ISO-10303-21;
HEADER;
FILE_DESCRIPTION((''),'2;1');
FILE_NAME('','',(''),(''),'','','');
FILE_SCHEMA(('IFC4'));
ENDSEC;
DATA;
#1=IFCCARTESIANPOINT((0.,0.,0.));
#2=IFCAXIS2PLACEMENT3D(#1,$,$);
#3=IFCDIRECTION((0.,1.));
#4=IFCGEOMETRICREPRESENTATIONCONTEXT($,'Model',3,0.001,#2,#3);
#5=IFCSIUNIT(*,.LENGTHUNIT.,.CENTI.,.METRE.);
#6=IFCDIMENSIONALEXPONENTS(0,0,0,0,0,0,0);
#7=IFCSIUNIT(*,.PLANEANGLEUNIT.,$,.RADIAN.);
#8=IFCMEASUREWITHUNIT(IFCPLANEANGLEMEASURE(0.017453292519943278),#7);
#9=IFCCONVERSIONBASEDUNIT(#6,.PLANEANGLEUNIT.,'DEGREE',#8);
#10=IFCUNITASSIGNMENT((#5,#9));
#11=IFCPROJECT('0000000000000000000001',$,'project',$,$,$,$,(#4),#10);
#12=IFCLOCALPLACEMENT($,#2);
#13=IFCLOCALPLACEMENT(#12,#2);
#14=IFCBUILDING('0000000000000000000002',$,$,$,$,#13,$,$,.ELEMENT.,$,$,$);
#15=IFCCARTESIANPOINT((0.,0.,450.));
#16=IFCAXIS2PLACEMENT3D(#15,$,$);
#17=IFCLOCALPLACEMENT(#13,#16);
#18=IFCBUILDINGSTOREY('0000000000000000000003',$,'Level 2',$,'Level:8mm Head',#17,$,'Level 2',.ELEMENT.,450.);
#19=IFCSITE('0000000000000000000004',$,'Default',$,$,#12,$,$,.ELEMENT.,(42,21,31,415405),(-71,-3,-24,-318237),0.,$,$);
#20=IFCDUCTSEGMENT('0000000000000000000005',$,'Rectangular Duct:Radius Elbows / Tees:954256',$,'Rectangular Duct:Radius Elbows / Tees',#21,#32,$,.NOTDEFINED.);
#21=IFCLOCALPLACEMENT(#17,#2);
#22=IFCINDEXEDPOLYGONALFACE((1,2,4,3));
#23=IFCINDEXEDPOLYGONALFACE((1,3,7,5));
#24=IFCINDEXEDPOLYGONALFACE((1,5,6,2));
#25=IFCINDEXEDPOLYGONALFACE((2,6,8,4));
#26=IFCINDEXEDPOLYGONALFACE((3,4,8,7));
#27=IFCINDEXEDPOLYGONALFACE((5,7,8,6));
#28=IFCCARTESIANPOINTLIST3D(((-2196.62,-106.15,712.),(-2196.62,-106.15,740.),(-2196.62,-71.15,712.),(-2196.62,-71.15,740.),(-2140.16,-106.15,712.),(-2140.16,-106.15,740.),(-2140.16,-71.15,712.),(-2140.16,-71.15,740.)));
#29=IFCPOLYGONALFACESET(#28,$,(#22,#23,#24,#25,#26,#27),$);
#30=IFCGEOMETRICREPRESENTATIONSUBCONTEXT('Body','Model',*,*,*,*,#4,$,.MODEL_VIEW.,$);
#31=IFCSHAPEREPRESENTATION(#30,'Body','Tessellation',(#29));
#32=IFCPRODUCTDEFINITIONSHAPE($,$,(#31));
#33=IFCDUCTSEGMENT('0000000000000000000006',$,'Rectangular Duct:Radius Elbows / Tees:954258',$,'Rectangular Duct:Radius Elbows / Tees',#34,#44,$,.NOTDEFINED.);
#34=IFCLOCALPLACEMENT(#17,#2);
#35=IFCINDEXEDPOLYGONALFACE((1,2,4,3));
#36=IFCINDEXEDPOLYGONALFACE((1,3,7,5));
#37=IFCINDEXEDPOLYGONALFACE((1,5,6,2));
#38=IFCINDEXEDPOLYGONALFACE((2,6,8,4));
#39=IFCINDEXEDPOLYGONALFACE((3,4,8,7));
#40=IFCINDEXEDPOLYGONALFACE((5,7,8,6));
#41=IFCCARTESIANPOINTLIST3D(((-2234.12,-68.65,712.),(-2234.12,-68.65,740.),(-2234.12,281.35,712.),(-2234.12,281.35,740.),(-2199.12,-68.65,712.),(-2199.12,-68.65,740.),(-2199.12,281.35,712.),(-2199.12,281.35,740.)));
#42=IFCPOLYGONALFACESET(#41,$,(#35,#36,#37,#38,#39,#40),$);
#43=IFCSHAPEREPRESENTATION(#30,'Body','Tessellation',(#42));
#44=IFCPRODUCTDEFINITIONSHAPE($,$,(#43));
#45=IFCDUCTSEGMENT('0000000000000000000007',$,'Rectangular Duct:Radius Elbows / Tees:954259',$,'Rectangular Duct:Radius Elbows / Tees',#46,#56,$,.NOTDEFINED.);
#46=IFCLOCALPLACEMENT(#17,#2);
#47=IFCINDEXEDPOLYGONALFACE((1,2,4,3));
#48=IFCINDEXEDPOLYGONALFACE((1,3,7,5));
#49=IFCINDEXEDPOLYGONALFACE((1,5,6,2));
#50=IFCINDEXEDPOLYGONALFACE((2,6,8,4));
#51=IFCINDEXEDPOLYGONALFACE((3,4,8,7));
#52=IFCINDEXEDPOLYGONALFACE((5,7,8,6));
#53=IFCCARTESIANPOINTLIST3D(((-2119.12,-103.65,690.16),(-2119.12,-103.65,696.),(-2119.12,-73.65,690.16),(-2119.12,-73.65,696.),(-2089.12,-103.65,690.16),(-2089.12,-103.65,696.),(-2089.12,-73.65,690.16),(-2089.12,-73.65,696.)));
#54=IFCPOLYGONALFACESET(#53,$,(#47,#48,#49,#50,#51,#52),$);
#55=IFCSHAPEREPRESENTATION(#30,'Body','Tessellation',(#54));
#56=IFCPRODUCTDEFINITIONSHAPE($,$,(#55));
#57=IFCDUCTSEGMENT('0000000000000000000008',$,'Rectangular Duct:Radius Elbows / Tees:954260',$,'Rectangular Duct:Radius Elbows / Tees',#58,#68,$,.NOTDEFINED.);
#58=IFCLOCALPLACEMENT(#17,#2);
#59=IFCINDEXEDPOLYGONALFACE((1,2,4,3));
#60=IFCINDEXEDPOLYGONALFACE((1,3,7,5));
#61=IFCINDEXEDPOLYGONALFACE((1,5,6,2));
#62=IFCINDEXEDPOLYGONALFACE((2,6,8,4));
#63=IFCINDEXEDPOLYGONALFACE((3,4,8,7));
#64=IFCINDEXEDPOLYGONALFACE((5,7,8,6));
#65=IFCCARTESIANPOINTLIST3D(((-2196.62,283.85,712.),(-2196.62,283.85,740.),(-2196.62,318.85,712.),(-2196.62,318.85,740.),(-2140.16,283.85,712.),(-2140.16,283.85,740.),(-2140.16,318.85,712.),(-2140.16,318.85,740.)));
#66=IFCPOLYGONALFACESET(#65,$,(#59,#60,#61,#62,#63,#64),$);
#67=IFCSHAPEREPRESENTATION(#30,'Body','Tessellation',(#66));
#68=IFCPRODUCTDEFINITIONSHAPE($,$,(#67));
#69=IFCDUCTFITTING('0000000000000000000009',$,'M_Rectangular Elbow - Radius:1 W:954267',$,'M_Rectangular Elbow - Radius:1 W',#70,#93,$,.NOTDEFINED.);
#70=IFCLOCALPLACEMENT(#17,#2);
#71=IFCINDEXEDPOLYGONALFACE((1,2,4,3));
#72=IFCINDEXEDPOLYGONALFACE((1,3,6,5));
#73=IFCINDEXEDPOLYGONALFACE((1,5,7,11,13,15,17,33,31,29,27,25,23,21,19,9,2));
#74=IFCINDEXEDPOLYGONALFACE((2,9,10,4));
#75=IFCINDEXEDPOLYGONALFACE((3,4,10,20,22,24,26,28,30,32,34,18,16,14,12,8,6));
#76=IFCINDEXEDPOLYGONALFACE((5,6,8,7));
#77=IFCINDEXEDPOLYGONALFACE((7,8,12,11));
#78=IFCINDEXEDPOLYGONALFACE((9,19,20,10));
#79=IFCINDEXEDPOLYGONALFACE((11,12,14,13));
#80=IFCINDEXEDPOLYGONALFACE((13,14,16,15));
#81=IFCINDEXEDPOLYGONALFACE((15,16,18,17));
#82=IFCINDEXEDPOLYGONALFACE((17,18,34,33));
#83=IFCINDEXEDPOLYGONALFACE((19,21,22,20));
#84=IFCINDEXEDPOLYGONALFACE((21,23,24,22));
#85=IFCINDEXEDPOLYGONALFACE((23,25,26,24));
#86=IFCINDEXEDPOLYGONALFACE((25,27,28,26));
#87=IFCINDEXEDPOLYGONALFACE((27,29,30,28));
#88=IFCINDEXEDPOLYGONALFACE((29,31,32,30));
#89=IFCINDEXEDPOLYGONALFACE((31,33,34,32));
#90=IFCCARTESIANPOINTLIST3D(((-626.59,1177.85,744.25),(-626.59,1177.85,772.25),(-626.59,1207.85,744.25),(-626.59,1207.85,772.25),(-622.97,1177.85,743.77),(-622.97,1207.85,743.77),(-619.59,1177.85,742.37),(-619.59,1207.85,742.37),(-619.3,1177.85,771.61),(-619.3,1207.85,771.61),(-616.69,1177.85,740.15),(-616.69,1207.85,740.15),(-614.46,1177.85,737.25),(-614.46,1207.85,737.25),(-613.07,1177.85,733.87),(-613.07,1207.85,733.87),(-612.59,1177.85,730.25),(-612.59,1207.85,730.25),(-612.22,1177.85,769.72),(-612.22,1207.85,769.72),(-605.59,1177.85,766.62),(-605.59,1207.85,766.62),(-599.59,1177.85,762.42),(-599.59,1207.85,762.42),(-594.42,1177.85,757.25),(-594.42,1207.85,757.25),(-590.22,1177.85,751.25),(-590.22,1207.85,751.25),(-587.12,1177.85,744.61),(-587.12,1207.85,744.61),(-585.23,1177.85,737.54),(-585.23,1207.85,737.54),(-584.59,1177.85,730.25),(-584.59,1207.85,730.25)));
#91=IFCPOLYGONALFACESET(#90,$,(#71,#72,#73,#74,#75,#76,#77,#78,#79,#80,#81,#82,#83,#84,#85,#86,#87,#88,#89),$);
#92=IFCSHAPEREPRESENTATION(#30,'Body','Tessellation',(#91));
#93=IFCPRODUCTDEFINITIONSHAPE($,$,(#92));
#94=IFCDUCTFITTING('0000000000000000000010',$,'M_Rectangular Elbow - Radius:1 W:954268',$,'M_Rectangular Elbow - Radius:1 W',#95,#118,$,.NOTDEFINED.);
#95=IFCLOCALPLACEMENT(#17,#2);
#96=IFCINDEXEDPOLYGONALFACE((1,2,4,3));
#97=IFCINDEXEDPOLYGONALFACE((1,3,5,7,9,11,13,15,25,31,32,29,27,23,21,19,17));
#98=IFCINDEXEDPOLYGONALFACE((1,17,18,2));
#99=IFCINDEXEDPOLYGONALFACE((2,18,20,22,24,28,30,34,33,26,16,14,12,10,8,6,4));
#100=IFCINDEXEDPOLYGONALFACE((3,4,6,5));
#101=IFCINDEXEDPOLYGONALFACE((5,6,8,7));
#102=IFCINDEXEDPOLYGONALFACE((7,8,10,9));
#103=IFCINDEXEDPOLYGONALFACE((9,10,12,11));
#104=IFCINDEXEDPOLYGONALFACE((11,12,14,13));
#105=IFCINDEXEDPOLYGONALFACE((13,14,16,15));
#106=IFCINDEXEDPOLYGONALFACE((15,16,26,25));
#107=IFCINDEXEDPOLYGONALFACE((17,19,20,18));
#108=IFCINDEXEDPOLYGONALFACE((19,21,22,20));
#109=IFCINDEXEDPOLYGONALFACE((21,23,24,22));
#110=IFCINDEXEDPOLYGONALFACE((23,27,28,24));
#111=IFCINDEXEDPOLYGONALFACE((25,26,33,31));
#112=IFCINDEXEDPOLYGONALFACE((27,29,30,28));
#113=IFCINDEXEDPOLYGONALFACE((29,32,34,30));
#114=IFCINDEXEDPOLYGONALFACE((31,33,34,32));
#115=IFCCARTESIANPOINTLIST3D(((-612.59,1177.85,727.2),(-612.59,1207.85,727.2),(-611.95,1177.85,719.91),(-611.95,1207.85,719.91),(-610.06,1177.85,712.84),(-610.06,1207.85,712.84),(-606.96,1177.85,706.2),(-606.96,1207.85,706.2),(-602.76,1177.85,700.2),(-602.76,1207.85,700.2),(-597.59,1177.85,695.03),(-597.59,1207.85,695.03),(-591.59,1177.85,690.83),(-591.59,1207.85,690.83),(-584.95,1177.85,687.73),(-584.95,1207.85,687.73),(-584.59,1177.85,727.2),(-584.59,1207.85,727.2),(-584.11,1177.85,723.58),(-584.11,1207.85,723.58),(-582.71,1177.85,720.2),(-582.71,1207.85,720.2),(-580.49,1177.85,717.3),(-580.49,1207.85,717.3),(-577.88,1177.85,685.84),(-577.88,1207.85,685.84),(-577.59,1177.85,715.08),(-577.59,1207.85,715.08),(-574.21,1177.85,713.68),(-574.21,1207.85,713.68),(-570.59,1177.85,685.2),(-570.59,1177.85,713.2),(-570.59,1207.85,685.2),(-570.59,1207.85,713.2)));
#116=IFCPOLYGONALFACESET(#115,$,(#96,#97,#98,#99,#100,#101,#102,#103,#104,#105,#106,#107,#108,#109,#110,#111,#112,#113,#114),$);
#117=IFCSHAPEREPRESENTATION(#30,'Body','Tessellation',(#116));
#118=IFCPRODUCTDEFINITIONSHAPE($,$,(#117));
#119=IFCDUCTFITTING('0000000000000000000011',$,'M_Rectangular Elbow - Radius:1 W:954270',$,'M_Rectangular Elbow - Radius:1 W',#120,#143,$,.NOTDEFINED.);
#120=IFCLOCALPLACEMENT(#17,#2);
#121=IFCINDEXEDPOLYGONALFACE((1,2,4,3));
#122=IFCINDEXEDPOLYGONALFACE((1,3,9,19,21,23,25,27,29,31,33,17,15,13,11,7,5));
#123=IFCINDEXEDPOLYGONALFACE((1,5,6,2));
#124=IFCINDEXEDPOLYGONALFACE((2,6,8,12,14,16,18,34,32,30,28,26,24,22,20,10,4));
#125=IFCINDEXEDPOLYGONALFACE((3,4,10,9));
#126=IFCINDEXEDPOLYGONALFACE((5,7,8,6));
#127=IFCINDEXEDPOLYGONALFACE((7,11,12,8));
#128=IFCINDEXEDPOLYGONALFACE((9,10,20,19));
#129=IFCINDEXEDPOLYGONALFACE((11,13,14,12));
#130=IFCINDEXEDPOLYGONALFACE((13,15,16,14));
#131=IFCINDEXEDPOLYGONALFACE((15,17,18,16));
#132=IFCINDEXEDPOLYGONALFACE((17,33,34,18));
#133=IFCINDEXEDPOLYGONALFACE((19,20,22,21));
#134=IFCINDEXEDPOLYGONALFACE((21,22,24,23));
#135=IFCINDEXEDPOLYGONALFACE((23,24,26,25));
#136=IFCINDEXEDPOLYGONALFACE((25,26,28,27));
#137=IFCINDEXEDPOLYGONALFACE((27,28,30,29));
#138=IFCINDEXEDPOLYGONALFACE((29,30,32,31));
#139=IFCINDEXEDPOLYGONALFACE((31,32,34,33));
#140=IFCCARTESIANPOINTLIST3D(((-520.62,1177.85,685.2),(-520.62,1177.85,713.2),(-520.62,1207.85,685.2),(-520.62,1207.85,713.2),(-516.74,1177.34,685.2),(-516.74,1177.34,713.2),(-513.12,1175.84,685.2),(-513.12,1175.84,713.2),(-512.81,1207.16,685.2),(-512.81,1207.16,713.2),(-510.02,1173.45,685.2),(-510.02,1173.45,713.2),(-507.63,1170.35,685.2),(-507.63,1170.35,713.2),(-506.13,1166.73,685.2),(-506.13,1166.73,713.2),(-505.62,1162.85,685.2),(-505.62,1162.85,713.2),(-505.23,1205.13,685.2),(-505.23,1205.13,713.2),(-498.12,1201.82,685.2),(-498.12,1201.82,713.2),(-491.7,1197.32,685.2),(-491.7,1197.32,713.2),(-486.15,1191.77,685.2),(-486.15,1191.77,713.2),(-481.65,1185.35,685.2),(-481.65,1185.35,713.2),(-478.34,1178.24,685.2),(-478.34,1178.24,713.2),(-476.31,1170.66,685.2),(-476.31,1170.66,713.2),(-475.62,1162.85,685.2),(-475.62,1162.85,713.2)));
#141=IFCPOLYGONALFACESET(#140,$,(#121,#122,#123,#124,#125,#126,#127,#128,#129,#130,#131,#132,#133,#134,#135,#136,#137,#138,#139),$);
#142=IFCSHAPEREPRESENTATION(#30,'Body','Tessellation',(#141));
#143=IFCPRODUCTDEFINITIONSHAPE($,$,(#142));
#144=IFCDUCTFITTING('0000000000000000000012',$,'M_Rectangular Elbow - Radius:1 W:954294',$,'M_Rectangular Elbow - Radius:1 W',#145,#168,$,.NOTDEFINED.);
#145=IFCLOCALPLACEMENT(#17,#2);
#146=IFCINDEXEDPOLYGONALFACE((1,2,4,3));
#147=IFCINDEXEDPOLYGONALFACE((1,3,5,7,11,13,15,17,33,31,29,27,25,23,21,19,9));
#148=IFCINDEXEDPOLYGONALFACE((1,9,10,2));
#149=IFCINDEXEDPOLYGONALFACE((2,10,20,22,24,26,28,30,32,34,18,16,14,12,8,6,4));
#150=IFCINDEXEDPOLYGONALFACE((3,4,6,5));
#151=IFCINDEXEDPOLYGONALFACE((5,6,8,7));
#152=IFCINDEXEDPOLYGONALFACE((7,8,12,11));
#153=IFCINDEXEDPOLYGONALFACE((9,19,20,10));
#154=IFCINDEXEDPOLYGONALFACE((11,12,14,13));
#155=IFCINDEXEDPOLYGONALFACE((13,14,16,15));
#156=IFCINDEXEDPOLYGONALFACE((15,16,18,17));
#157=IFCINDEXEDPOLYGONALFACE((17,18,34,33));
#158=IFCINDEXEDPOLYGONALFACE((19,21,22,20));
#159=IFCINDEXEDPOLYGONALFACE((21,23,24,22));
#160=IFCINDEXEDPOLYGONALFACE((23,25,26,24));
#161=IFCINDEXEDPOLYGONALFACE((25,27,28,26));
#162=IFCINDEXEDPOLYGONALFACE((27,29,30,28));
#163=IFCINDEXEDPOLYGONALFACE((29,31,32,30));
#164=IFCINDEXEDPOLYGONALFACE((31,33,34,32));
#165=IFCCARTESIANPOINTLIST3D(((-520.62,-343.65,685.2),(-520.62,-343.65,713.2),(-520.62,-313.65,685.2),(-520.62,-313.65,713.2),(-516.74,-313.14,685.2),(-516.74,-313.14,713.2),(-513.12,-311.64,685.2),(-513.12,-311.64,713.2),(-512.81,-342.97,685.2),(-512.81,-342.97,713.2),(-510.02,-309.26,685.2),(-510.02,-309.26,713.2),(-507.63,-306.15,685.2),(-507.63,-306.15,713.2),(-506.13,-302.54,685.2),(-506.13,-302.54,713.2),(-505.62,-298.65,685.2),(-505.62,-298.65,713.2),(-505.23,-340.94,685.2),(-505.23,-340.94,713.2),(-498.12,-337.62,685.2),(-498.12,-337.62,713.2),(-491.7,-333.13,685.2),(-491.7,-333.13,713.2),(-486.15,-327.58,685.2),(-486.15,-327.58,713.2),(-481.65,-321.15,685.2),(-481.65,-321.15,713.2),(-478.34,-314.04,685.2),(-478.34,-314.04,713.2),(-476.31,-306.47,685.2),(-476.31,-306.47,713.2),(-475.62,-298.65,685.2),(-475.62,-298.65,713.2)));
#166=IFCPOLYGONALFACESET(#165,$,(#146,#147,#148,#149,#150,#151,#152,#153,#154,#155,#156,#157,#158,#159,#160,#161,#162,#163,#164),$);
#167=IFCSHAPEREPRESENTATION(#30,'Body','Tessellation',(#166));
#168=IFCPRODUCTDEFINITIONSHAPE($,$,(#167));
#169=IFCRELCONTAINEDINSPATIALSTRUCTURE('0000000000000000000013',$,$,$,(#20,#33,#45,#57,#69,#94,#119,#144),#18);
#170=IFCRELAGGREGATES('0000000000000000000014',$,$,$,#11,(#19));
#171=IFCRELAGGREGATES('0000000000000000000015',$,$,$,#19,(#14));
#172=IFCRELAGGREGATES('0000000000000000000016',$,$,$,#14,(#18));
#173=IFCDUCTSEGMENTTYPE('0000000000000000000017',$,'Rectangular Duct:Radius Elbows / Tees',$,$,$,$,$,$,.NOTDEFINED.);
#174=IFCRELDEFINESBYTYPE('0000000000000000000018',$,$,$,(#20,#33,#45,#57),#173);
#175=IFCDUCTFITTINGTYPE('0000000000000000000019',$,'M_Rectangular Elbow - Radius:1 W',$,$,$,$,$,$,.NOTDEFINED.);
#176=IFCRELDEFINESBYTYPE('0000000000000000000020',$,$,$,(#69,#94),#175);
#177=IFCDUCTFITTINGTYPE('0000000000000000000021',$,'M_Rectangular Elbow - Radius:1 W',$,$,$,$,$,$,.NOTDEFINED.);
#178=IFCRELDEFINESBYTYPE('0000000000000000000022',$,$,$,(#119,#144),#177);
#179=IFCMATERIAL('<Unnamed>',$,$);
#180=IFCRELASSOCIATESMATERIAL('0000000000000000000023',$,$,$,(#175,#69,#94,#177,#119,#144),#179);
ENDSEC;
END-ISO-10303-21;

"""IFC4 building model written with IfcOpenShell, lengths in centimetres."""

from ifc_helpers import new_model, entity, si_unit, converted_unit, direction, frame, origin, place, context, subcontext, project, spatial, line, arc, indexed_curve, outline, extrude, source, transform, mapped, material, type_object, type_shapes, element, save


model = new_model("IFC4")

# Units and contexts
model_context = context("Model", 3, precision=0.001, world=origin(), true_north=direction((0.0, 1.0)))
body_context = subcontext(model_context, "Body", "Model", "MODEL_VIEW")
ifc_project = project(units=[si_unit("LENGTHUNIT", "METRE", prefix="CENTI"), converted_unit("PLANEANGLEUNIT", "DEGREE", entity("IfcPlaneAngleMeasure", 0.017453292519943278), si_unit("PLANEANGLEUNIT", "RADIAN"), dimensions=[0, 0, 0, 0, 0, 0, 0])], contexts=[model_context])

# Site, building, storey
site_placement = place(None, origin())
site = spatial("IfcSite", under=ifc_project, at=site_placement, Name="Default", CompositionType="ELEMENT", RefLatitude=(42, 21, 31, 415405), RefLongitude=(-71, -3, -24, -318237), RefElevation=0.0)
building_placement = place(site_placement, origin())
building = spatial("IfcBuilding", under=site, at=building_placement, CompositionType="ELEMENT")
storey_placement = place(building_placement, frame((0.0, 0.0, 450.0)))
storey = spatial("IfcBuildingStorey", under=building, at=storey_placement, Name="Level 2", ObjectType="Level:8mm Head", LongName="Level 2", CompositionType="ELEMENT", Elevation=450.0)

# Duct segments
duct_segment_type_1 = type_object("IfcDuctSegmentType", Name="Rectangular Duct:Radius Elbows / Tees", PredefinedType="NOTDEFINED")
duct_segment_1_placement = place(storey_placement, origin())
element("IfcDuctSegment", 1, at=duct_segment_1_placement, inside=storey, type_object=duct_segment_type_1, Name="Rectangular Duct:Radius Elbows / Tees:954256", ObjectType="Rectangular Duct:Radius Elbows / Tees", PredefinedType="NOTDEFINED", context=body_context, shape_type="SweptSolid", body=[
    extrude(outline(indexed_curve([(-28.23, -17.5), (28.23, -17.5), (28.23, 17.5), (-28.23, 17.5), (-28.23, -17.5)], self_intersect=False)), frame((-2168.39, -88.65, 712.0), z_axis=(0.0, 0.0, 1.0), x_axis=(-1.0, 0.0, 0.0)), (0.0, 0.0, 1.0), 28.0),
])
duct_segment_2_placement = place(storey_placement, origin())
element("IfcDuctSegment", 2, at=duct_segment_2_placement, inside=storey, type_object=duct_segment_type_1, Name="Rectangular Duct:Radius Elbows / Tees:954258", ObjectType="Rectangular Duct:Radius Elbows / Tees", PredefinedType="NOTDEFINED", context=body_context, shape_type="SweptSolid", body=[
    extrude(outline(indexed_curve([(-175.0, -17.5), (175.0, -17.5), (175.0, 17.5), (-175.0, 17.5), (-175.0, -17.5)], self_intersect=False)), frame((-2216.62, 106.35, 712.0), z_axis=(0.0, 0.0, 1.0), x_axis=(0.0, -1.0, 0.0)), (0.0, 0.0, 1.0), 28.0),
])
duct_segment_3_placement = place(storey_placement, origin())
element("IfcDuctSegment", 3, at=duct_segment_3_placement, inside=storey, type_object=duct_segment_type_1, Name="Rectangular Duct:Radius Elbows / Tees:954259", ObjectType="Rectangular Duct:Radius Elbows / Tees", PredefinedType="NOTDEFINED", context=body_context, shape_type="SweptSolid", body=[
    extrude(outline(indexed_curve([(-15.0, -15.0), (15.0, -15.0), (15.0, 15.0), (-15.0, 15.0), (-15.0, -15.0)], self_intersect=False)), frame((-2104.12, -88.65, 690.16)), (0.0, 0.0, 1.0), 5.84),
])
duct_segment_4_placement = place(storey_placement, origin())
element("IfcDuctSegment", 4, at=duct_segment_4_placement, inside=storey, type_object=duct_segment_type_1, Name="Rectangular Duct:Radius Elbows / Tees:954260", ObjectType="Rectangular Duct:Radius Elbows / Tees", PredefinedType="NOTDEFINED", context=body_context, shape_type="SweptSolid", body=[
    extrude(outline(indexed_curve([(-28.23, -17.5), (28.23, -17.5), (28.23, 17.5), (-28.23, 17.5), (-28.23, -17.5)], self_intersect=False)), frame((-2168.39, 301.35, 712.0), z_axis=(0.0, 0.0, 1.0), x_axis=(-1.0, 0.0, 0.0)), (0.0, 0.0, 1.0), 28.0),
])

# Duct fittings
ifc_material = material(Name="<Unnamed>")
duct_fitting_type_1 = type_object("IfcDuctFittingType", Name="M_Rectangular Elbow - Radius:1 W", PredefinedType="NOTDEFINED", material=ifc_material)
shared_shape_1 = source(origin(), body_context, "Body", "SweptSolid", [
    extrude(outline(indexed_curve([(-28.0, -14.0), (0.0, -14.0), (4.1, -4.1), (14.0, 0.0), (14.0, 28.0), (-15.7, 15.7)], segments=[line(1, 2), arc(2, 3, 4), line(4, 5), arc(5, 6, 1)], self_intersect=False)), frame((-14.0, 14.0, -15.0), z_axis=(0.0, 0.0, 1.0), x_axis=(-1.0, 0.0, 0.0)), (0.0, 0.0, 1.0), 30.0),
])
type_shapes(duct_fitting_type_1, [shared_shape_1])
for number, where, z_axis, x_axis, name in (
    (5, (-598.59, 1192.85, 758.25), (0.0, 1.0, 0.0), (1.0, 0.0, 0.0), "M_Rectangular Elbow - Radius:1 W:954267"),
    (6, (-598.59, 1192.85, 699.2), (0.0, -1.0, 0.0), (0.0, 0.0, -1.0), "M_Rectangular Elbow - Radius:1 W:954268"),
):
    element("IfcDuctFitting", number, at=place(storey_placement, frame(where, z_axis=z_axis, x_axis=x_axis)), inside=storey, type_object=duct_fitting_type_1, material=ifc_material, Name=name, ObjectType="M_Rectangular Elbow - Radius:1 W", PredefinedType="NOTDEFINED", context=body_context, shape_type="MappedRepresentation", body=[
        mapped(shared_shape_1, transform((0.0, 0.0, 0.0), scale=1.0)),
    ])
duct_fitting_type_2 = type_object("IfcDuctFittingType", Name="M_Rectangular Elbow - Radius:1 W", PredefinedType="NOTDEFINED", material=ifc_material)
shared_shape_2 = source(origin(), body_context, "Body", "SweptSolid", [
    extrude(outline(indexed_curve([(-30.0, -15.0), (0.0, -15.0), (4.39, -4.39), (15.0, 0.0), (15.0, 30.0), (-16.82, 16.82)], segments=[line(1, 2), arc(2, 3, 4), line(4, 5), arc(5, 6, 1)], self_intersect=False)), frame((-15.0, 15.0, -14.0), z_axis=(0.0, 0.0, 1.0), x_axis=(-1.0, 0.0, 0.0)), (0.0, 0.0, 1.0), 28.0),
])
type_shapes(duct_fitting_type_2, [shared_shape_2])
duct_fitting_1_placement = place(storey_placement, frame((-490.62, 1192.85, 699.2), z_axis=(0.0, 0.0, 1.0), x_axis=(0.0, 1.0, 0.0)))
element("IfcDuctFitting", 7, at=duct_fitting_1_placement, inside=storey, type_object=duct_fitting_type_2, material=ifc_material, Name="M_Rectangular Elbow - Radius:1 W:954270", ObjectType="M_Rectangular Elbow - Radius:1 W", PredefinedType="NOTDEFINED", context=body_context, shape_type="MappedRepresentation", body=[
    mapped(shared_shape_2, transform((0.0, 0.0, 0.0), scale=1.0)),
])
duct_fitting_2_placement = place(storey_placement, frame((-490.62, -328.65, 699.2)))
element("IfcDuctFitting", 8, at=duct_fitting_2_placement, inside=storey, type_object=duct_fitting_type_2, material=ifc_material, Name="M_Rectangular Elbow - Radius:1 W:954294", ObjectType="M_Rectangular Elbow - Radius:1 W", PredefinedType="NOTDEFINED", context=body_context, shape_type="MappedRepresentation", body=[
    mapped(shared_shape_2, transform((0.0, 0.0, 0.0), scale=1.0)),
])

save(model, "model.ifc")
